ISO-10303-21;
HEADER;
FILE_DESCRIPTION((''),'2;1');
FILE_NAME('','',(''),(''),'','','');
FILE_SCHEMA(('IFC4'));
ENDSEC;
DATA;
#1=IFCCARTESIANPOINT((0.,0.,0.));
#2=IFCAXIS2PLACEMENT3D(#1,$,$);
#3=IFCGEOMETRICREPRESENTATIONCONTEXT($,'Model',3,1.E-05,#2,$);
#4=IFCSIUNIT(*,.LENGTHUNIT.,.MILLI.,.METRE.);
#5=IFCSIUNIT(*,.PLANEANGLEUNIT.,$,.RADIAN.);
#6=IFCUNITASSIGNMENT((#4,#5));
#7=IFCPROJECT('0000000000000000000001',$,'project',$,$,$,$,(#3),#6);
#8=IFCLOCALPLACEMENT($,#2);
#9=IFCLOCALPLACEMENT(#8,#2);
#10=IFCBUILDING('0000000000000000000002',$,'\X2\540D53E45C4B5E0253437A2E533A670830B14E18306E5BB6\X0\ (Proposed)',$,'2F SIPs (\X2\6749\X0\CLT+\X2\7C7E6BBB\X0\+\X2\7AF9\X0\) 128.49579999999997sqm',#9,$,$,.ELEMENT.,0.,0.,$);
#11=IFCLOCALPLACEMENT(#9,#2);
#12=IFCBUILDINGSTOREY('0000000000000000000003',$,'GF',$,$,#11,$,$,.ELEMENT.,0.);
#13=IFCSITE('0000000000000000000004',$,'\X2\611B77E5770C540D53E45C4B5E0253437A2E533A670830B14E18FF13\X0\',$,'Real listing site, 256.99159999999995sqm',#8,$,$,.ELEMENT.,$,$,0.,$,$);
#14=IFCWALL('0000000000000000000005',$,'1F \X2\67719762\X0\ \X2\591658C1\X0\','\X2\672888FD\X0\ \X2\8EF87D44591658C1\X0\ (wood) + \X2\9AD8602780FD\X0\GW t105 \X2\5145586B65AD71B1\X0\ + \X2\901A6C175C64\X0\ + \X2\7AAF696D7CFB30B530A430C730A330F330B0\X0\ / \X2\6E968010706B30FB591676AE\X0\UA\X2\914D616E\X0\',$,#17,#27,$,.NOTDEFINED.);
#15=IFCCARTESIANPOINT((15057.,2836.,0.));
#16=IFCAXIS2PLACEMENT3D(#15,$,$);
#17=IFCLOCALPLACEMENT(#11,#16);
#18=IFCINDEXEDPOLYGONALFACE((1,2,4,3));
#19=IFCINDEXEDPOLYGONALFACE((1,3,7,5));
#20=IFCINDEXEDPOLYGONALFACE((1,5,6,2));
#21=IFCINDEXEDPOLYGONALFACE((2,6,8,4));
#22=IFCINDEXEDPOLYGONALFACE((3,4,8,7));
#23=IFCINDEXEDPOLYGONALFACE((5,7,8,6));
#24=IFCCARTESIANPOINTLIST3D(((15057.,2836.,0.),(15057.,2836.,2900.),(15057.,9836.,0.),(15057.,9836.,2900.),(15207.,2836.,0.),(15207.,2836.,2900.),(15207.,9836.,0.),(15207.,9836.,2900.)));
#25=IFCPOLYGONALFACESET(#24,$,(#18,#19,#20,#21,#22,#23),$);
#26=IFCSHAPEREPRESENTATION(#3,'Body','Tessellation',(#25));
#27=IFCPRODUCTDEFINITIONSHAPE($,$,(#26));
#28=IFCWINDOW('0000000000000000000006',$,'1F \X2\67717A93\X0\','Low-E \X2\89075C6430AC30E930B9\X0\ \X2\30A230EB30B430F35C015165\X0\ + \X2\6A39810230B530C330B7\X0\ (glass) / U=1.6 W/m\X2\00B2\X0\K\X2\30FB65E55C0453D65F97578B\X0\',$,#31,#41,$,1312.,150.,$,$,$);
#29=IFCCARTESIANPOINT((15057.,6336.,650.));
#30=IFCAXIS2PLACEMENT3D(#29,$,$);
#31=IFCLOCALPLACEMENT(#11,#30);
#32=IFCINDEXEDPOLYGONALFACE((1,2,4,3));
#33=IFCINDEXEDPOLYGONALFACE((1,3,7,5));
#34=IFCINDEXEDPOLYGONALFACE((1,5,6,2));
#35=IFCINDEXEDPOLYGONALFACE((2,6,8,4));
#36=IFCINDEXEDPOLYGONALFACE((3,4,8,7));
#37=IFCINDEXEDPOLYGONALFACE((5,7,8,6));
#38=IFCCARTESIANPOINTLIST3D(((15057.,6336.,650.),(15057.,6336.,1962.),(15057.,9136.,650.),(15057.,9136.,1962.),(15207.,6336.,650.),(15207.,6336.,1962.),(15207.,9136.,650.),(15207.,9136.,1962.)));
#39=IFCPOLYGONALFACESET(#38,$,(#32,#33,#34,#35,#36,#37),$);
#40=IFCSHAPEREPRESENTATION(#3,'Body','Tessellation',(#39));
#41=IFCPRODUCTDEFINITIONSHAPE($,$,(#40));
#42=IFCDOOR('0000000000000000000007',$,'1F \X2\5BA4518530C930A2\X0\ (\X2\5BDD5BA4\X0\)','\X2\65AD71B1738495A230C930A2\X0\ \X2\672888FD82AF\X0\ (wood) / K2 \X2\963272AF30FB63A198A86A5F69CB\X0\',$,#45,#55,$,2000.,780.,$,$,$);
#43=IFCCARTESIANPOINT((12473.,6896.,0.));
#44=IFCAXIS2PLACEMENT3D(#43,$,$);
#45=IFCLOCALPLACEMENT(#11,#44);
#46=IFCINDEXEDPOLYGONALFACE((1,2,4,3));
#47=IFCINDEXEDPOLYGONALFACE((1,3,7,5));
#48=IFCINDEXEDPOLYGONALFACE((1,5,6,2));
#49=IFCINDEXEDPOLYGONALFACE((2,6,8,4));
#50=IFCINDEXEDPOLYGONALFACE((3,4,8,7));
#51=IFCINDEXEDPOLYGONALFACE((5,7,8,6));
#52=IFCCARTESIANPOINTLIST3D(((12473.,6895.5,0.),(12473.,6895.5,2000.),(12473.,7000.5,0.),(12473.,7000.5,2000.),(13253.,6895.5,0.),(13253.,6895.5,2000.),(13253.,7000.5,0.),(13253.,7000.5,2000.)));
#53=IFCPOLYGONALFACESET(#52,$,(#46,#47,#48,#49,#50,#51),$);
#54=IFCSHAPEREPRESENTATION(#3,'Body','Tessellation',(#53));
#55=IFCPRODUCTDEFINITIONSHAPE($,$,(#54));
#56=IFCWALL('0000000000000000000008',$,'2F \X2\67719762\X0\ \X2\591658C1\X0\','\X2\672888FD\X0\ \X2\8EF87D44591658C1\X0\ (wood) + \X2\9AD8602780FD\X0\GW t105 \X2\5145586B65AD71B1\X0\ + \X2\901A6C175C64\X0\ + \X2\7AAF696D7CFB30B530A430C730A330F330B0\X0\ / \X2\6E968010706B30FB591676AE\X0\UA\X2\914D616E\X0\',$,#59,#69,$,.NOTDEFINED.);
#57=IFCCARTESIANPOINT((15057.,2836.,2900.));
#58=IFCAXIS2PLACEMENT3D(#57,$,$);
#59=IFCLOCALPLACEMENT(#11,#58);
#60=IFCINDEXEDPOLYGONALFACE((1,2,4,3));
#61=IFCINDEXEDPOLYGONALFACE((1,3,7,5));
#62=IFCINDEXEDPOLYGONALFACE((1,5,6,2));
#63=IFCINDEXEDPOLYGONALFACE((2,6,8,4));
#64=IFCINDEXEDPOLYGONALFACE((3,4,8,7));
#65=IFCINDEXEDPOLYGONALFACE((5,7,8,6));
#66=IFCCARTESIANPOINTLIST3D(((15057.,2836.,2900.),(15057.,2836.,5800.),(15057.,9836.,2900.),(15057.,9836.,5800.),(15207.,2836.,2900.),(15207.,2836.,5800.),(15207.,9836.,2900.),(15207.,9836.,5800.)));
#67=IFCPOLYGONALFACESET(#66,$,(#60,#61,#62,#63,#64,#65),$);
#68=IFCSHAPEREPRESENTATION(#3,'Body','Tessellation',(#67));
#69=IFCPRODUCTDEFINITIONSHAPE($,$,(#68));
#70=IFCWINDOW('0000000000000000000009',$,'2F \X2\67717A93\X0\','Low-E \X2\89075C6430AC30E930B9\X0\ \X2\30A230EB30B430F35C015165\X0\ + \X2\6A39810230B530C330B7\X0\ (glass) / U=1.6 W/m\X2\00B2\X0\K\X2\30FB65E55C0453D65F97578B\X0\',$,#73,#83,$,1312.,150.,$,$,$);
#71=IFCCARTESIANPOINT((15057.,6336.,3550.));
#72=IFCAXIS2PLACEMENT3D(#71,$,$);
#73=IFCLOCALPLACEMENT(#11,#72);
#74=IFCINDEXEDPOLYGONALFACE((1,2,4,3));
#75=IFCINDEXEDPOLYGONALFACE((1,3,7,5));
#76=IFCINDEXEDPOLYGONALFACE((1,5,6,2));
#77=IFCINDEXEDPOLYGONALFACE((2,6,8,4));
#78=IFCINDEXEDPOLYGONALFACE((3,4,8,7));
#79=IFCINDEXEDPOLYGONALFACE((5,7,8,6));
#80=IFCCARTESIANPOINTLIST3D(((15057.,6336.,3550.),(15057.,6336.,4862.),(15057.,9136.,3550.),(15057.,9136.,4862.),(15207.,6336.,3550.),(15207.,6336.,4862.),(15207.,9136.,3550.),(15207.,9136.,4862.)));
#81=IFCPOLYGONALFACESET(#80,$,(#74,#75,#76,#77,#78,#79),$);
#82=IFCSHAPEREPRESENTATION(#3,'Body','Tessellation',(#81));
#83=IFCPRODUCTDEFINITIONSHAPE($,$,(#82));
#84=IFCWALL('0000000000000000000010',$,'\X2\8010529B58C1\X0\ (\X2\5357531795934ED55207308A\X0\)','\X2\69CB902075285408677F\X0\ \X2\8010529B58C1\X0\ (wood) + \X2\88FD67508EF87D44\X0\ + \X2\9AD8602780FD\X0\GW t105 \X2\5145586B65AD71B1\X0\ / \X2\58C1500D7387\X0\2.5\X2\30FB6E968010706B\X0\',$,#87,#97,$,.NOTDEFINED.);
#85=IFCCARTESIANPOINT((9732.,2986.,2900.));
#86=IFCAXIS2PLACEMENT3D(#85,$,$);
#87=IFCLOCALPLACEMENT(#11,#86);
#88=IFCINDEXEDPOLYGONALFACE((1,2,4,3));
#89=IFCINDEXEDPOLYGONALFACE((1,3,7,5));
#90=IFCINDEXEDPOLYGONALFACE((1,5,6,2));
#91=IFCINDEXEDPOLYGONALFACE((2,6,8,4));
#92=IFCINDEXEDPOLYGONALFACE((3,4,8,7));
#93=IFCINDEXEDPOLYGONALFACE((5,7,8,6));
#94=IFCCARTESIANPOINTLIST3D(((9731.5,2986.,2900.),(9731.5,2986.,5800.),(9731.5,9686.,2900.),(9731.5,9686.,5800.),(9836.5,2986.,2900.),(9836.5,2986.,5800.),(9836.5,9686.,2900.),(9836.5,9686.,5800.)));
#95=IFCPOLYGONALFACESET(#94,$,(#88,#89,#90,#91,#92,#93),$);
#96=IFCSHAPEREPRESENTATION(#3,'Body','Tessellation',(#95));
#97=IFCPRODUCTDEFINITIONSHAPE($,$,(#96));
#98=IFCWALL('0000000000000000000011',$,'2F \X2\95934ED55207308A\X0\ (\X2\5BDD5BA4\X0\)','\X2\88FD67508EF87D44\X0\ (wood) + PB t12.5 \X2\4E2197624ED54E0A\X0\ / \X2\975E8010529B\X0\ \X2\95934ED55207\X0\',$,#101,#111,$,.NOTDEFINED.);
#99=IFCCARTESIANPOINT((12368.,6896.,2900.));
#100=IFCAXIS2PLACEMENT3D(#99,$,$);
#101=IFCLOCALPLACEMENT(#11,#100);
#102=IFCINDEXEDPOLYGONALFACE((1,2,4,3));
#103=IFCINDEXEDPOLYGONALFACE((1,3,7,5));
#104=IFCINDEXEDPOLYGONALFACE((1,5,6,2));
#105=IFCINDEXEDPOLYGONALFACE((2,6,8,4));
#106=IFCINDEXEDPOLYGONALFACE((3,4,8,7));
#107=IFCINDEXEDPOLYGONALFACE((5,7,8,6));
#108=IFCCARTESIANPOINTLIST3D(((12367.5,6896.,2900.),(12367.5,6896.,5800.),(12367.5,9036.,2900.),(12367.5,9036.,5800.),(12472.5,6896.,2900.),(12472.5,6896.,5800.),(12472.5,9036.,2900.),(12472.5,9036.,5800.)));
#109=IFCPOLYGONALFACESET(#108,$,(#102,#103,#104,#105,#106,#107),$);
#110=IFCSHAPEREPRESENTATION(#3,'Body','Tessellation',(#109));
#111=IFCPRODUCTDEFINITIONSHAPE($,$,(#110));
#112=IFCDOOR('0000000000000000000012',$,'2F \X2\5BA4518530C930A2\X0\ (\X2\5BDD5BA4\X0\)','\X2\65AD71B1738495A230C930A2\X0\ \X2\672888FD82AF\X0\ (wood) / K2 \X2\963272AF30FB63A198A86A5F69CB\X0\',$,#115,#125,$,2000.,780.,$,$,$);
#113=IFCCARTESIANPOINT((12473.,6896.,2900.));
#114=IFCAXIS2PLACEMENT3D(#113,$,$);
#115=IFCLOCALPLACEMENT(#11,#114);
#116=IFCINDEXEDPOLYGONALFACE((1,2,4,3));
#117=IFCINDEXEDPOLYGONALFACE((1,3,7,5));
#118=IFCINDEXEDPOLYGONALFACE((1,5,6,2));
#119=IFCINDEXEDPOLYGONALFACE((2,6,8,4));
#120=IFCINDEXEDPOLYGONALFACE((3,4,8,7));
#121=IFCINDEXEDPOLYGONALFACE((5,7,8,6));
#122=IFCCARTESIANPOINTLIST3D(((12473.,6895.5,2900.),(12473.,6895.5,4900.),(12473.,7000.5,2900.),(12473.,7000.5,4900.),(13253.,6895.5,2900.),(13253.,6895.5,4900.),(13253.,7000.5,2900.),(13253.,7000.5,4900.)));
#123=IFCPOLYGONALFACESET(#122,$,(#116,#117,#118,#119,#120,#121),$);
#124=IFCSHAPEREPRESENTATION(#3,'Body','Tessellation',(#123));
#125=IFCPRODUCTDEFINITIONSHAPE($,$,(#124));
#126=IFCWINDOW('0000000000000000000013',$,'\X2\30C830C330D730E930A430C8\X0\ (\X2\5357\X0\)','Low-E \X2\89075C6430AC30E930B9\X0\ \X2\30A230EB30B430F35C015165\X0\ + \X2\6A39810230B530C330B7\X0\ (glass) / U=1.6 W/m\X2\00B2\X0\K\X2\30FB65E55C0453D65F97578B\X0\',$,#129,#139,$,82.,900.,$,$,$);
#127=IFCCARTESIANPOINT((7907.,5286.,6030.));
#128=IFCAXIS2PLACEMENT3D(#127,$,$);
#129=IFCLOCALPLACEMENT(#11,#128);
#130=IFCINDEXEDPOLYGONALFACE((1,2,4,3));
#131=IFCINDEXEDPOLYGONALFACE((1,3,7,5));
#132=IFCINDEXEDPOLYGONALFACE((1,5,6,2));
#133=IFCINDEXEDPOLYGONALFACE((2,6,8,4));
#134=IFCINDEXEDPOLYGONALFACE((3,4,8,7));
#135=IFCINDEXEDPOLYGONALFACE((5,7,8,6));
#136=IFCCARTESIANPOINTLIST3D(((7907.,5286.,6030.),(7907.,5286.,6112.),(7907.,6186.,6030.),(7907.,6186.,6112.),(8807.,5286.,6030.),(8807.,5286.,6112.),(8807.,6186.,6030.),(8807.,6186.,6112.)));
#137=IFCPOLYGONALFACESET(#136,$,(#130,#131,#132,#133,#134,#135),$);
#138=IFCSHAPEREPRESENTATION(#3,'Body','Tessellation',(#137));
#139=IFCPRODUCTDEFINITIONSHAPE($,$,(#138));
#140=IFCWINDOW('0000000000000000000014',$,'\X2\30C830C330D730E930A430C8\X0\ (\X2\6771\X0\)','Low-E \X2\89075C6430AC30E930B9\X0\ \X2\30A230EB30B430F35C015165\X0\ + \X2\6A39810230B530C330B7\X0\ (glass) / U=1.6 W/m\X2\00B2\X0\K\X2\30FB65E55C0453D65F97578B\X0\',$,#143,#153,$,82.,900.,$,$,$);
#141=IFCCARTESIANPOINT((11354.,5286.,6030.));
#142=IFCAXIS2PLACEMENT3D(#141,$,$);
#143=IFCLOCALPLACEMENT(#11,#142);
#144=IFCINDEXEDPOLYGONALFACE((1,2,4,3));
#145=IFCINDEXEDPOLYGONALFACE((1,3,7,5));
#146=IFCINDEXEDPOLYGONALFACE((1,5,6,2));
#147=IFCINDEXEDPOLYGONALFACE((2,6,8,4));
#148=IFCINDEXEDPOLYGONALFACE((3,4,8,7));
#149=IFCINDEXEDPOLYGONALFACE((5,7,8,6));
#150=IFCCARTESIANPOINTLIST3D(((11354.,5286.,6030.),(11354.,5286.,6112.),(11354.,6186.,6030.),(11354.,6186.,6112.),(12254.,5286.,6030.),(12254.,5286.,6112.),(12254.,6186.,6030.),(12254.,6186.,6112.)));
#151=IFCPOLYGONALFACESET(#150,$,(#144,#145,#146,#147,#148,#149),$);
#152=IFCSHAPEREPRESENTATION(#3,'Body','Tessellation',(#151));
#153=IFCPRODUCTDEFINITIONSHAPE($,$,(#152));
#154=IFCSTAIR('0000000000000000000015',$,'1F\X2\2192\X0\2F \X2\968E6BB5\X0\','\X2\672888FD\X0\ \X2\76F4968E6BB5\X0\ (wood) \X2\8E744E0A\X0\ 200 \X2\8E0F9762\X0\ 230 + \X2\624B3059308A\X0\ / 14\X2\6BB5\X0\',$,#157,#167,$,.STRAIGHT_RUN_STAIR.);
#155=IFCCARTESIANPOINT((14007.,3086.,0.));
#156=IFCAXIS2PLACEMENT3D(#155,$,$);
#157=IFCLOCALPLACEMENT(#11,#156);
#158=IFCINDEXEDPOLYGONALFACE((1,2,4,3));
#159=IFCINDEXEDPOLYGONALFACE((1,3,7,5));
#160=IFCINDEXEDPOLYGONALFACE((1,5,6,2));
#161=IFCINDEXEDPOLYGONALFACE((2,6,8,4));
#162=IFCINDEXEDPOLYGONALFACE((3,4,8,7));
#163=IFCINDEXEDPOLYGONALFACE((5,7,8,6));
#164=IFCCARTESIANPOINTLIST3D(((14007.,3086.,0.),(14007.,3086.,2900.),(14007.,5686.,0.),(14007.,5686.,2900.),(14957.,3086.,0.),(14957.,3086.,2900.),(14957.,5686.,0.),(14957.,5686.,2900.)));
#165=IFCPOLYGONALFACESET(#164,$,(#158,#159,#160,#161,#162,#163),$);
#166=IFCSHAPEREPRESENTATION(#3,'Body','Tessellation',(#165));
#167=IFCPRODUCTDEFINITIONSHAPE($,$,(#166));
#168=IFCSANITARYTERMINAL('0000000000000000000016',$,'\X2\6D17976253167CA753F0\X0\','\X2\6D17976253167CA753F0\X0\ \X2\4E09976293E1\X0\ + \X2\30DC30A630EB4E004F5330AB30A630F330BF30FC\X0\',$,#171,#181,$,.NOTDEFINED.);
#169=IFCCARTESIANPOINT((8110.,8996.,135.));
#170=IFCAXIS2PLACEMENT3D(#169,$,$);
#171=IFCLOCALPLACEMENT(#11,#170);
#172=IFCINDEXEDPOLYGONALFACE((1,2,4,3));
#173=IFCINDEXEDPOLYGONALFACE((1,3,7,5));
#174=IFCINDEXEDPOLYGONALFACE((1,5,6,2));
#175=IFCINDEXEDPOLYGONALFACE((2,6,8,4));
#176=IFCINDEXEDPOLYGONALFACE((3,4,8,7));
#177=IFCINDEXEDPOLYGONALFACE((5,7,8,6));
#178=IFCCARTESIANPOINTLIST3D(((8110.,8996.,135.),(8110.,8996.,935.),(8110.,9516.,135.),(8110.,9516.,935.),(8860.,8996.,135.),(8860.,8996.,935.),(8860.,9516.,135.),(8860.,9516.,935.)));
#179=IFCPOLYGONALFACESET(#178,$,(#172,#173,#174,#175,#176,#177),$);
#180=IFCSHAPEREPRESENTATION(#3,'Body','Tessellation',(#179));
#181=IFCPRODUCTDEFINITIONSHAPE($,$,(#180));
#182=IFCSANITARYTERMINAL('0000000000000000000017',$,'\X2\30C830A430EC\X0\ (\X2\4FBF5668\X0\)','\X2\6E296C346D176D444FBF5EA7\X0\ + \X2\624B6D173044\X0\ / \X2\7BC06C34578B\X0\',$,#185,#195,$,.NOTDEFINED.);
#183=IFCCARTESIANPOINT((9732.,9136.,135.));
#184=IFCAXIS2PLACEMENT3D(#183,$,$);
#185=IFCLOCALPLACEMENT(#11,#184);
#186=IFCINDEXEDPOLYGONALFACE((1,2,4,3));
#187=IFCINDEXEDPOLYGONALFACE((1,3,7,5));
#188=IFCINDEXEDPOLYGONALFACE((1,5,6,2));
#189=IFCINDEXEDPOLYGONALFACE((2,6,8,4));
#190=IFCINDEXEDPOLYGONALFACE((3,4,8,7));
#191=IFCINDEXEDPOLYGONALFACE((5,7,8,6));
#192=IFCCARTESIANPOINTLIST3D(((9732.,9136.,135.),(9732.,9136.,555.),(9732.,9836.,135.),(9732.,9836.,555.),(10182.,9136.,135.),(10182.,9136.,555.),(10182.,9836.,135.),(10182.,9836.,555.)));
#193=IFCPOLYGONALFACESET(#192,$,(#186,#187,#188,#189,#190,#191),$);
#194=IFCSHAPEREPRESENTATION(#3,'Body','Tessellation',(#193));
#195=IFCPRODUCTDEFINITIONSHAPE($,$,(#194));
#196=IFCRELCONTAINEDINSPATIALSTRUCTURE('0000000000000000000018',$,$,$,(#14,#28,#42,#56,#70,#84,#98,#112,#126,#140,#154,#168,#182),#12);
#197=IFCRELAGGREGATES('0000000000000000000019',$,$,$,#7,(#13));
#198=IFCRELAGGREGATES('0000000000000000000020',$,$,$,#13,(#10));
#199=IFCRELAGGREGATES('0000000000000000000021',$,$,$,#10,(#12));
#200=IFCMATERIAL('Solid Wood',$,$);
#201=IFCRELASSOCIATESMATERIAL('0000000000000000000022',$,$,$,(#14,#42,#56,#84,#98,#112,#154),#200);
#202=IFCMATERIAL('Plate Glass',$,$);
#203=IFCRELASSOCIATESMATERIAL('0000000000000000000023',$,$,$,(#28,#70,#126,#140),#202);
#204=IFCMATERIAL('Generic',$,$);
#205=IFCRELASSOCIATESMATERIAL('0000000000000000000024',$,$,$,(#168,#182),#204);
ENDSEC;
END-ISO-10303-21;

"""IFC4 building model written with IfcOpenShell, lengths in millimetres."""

from ifc_helpers import new_model, si_unit, frame, frame_2d, origin, place, context, project, spatial, rectangle, extrude, material, element, fill, save


model = new_model("IFC4")

# Units and contexts
model_context = context("Model", 3, precision=1e-05, world=origin())
ifc_project = project(units=[si_unit("LENGTHUNIT", "METRE", prefix="MILLI"), si_unit("PLANEANGLEUNIT", "RADIAN")], contexts=[model_context])

# Site, building, storey
site_placement = place(None, origin())
site = spatial("IfcSite", under=ifc_project, at=site_placement, Name="愛知県名古屋市千種区月ケ丘３", ObjectType="Real listing site, 256.99159999999995sqm", CompositionType="ELEMENT", RefElevation=0.0)
building_placement = place(site_placement, origin())
building = spatial("IfcBuilding", under=site, at=building_placement, Name="名古屋市千種区月ケ丘の家 (Proposed)", ObjectType="2F SIPs (杉CLT+籾殻+竹) 128.49579999999997sqm", CompositionType="ELEMENT", ElevationOfRefHeight=0.0, ElevationOfTerrain=0.0)
storey_placement = place(building_placement, origin())
storey = spatial("IfcBuildingStorey", under=building, at=storey_placement, Name="GF", CompositionType="ELEMENT", Elevation=0.0)

# Wall, opening, window
ifc_material_1 = material(Name="Solid Wood")
wall_1_placement = place(storey_placement, frame((15057.0, 2836.0, 0.0)))
wall_1 = element("IfcWall", 1, at=wall_1_placement, inside=storey, material=ifc_material_1, Name="1F 東面 外壁", Description="木製 軸組外壁 (wood) + 高性能GW t105 充填断熱 + 通気層 + 窯業系サイディング / 準耐火・外皮UA配慮", PredefinedType="NOTDEFINED", context=model_context, shape_type="SweptSolid", body=[
    extrude(rectangle(XDim=150.0, YDim=7000.0, at=frame_2d((75.0, 3500.0))), frame((15057.0, 2836.0, 0.0)), (0.0, 0.0, 1.0), 2900.0),
])
opening_1_placement = place(storey_placement, frame((15057.0, 6336.0, 650.0)))
opening_1 = element("IfcOpeningElement", 2, at=opening_1_placement, cuts=wall_1, PredefinedType="NOTDEFINED", context=model_context, shape_type="SweptSolid", body=[
    extrude(rectangle(XDim=150.0, YDim=2800.0, at=frame_2d((75.0, 1400.0))), frame((15057.0, 6336.0, 650.0)), (0.0, 0.0, 1.0), 1312.0),
])
ifc_material_2 = material(Name="Plate Glass")
window_1_placement = place(storey_placement, frame((15057.0, 6336.0, 650.0)))
window_1 = element("IfcWindow", 3, at=window_1_placement, inside=storey, material=ifc_material_2, Name="1F 東窓", Description="Low-E 複層ガラス アルゴン封入 + 樹脂サッシ (glass) / U=1.6 W/m²K・日射取得型", OverallHeight=1312.0, OverallWidth=150.0, context=model_context, shape_type="SweptSolid", body=[
    extrude(rectangle(XDim=150.0, YDim=2800.0, at=frame_2d((75.0, 1400.0))), frame((15057.0, 6336.0, 650.0)), (0.0, 0.0, 1.0), 1312.0),
])
fill(opening_1, window_1)

# Door
door_1_placement = place(storey_placement, frame((12473.0, 6896.0, 0.0)))
element("IfcDoor", 4, at=door_1_placement, inside=storey, material=ifc_material_1, Name="1F 室内ドア (寝室)", Description="断熱玄関ドア 木製芯 (wood) / K2 防犯・採風機構", OverallHeight=2000.0, OverallWidth=780.0, context=model_context, shape_type="SweptSolid", body=[
    extrude(rectangle(XDim=780.0, YDim=105.0, at=frame_2d((390.0, 52.0))), frame((12473.0, 6896.0, 0.0)), (0.0, 0.0, 1.0), 2000.0),
])

# Wall, opening, window
wall_2_placement = place(storey_placement, frame((15057.0, 2836.0, 2900.0)))
wall_2 = element("IfcWall", 5, at=wall_2_placement, inside=storey, material=ifc_material_1, Name="2F 東面 外壁", Description="木製 軸組外壁 (wood) + 高性能GW t105 充填断熱 + 通気層 + 窯業系サイディング / 準耐火・外皮UA配慮", PredefinedType="NOTDEFINED", context=model_context, shape_type="SweptSolid", body=[
    extrude(rectangle(XDim=150.0, YDim=7000.0, at=frame_2d((75.0, 3500.0))), frame((15057.0, 2836.0, 2900.0)), (0.0, 0.0, 1.0), 2900.0),
])
opening_2_placement = place(storey_placement, frame((15057.0, 6336.0, 3550.0)))
opening_2 = element("IfcOpeningElement", 6, at=opening_2_placement, cuts=wall_2, PredefinedType="NOTDEFINED", context=model_context, shape_type="SweptSolid", body=[
    extrude(rectangle(XDim=150.0, YDim=2800.0, at=frame_2d((75.0, 1400.0))), frame((15057.0, 6336.0, 3550.0)), (0.0, 0.0, 1.0), 1312.0),
])
window_2_placement = place(storey_placement, frame((15057.0, 6336.0, 3550.0)))
window_2 = element("IfcWindow", 7, at=window_2_placement, inside=storey, material=ifc_material_2, Name="2F 東窓", Description="Low-E 複層ガラス アルゴン封入 + 樹脂サッシ (glass) / U=1.6 W/m²K・日射取得型", OverallHeight=1312.0, OverallWidth=150.0, context=model_context, shape_type="SweptSolid", body=[
    extrude(rectangle(XDim=150.0, YDim=2800.0, at=frame_2d((75.0, 1400.0))), frame((15057.0, 6336.0, 3550.0)), (0.0, 0.0, 1.0), 1312.0),
])
fill(opening_2, window_2)

# Walls
wall_3_placement = place(storey_placement, frame((9732.0, 2986.0, 2900.0)))
element("IfcWall", 8, at=wall_3_placement, inside=storey, material=ifc_material_1, Name="耐力壁 (南北間仕切り)", Description="構造用合板 耐力壁 (wood) + 製材軸組 + 高性能GW t105 充填断熱 / 壁倍率2.5・準耐火", PredefinedType="NOTDEFINED", context=model_context, shape_type="SweptSolid", body=[
    extrude(rectangle(XDim=105.0, YDim=6700.0, at=frame_2d((52.0, 3350.0))), frame((9732.0, 2986.0, 2900.0)), (0.0, 0.0, 1.0), 2900.0),
])
wall_4_placement = place(storey_placement, frame((12368.0, 6896.0, 2900.0)))
element("IfcWall", 9, at=wall_4_placement, inside=storey, material=ifc_material_1, Name="2F 間仕切り (寝室)", Description="製材軸組 (wood) + PB t12.5 両面仕上 / 非耐力 間仕切", PredefinedType="NOTDEFINED", context=model_context, shape_type="SweptSolid", body=[
    extrude(rectangle(XDim=105.0, YDim=2140.0, at=frame_2d((52.0, 1070.0))), frame((12368.0, 6896.0, 2900.0)), (0.0, 0.0, 1.0), 2900.0),
])

# Door
door_2_placement = place(storey_placement, frame((12473.0, 6896.0, 2900.0)))
element("IfcDoor", 10, at=door_2_placement, inside=storey, material=ifc_material_1, Name="2F 室内ドア (寝室)", Description="断熱玄関ドア 木製芯 (wood) / K2 防犯・採風機構", OverallHeight=2000.0, OverallWidth=780.0, context=model_context, shape_type="SweptSolid", body=[
    extrude(rectangle(XDim=780.0, YDim=105.0, at=frame_2d((390.0, 52.0))), frame((12473.0, 6896.0, 2900.0)), (0.0, 0.0, 1.0), 2000.0),
])

# Windows
window_3_placement = place(storey_placement, frame((7907.0, 5286.0, 6030.0)))
element("IfcWindow", 11, at=window_3_placement, inside=storey, material=ifc_material_2, Name="トップライト (南)", Description="Low-E 複層ガラス アルゴン封入 + 樹脂サッシ (glass) / U=1.6 W/m²K・日射取得型", OverallHeight=82.0, OverallWidth=900.0, context=model_context, shape_type="SweptSolid", body=[
    extrude(rectangle(XDim=900.0, YDim=900.0, at=frame_2d((450.0, 450.0))), frame((7907.0, 5286.0, 6030.0)), (0.0, 0.0, 1.0), 82.0),
])
window_4_placement = place(storey_placement, frame((11354.0, 5286.0, 6030.0)))
element("IfcWindow", 12, at=window_4_placement, inside=storey, material=ifc_material_2, Name="トップライト (東)", Description="Low-E 複層ガラス アルゴン封入 + 樹脂サッシ (glass) / U=1.6 W/m²K・日射取得型", OverallHeight=82.0, OverallWidth=900.0, context=model_context, shape_type="SweptSolid", body=[
    extrude(rectangle(XDim=900.0, YDim=900.0, at=frame_2d((450.0, 450.0))), frame((11354.0, 5286.0, 6030.0)), (0.0, 0.0, 1.0), 82.0),
])

# Stair
stair_placement = place(storey_placement, frame((14007.0, 3086.0, 0.0)))
element("IfcStair", 13, at=stair_placement, inside=storey, material=ifc_material_1, Name="1F→2F 階段", Description="木製 直階段 (wood) 蹴上 200 踏面 230 + 手すり / 14段", PredefinedType="STRAIGHT_RUN_STAIR", context=model_context, shape_type="SweptSolid", body=[
    extrude(rectangle(XDim=950.0, YDim=2600.0, at=frame_2d((475.0, 1300.0))), frame((14007.0, 3086.0, 0.0)), (0.0, 0.0, 1.0), 2900.0),
])

# Sanitary terminals
ifc_material_3 = material(Name="Generic")
sanitary_terminal_1_placement = place(storey_placement, frame((8110.0, 8996.0, 135.0)))
element("IfcSanitaryTerminal", 14, at=sanitary_terminal_1_placement, inside=storey, material=ifc_material_3, Name="洗面化粧台", Description="洗面化粧台 三面鏡 + ボウル一体カウンター", PredefinedType="NOTDEFINED", context=model_context, shape_type="SweptSolid", body=[
    extrude(rectangle(XDim=750.0, YDim=520.0, at=frame_2d((375.0, 260.0))), frame((8110.0, 8996.0, 135.0)), (0.0, 0.0, 1.0), 800.0),
])
sanitary_terminal_2_placement = place(storey_placement, frame((9732.0, 9136.0, 135.0)))
element("IfcSanitaryTerminal", 15, at=sanitary_terminal_2_placement, inside=storey, material=ifc_material_3, Name="トイレ (便器)", Description="温水洗浄便座 + 手洗い / 節水型", PredefinedType="NOTDEFINED", context=model_context, shape_type="SweptSolid", body=[
    extrude(rectangle(XDim=450.0, YDim=700.0, at=frame_2d((225.0, 350.0))), frame((9732.0, 9136.0, 135.0)), (0.0, 0.0, 1.0), 420.0),
])

save(model, "model.ifc")
